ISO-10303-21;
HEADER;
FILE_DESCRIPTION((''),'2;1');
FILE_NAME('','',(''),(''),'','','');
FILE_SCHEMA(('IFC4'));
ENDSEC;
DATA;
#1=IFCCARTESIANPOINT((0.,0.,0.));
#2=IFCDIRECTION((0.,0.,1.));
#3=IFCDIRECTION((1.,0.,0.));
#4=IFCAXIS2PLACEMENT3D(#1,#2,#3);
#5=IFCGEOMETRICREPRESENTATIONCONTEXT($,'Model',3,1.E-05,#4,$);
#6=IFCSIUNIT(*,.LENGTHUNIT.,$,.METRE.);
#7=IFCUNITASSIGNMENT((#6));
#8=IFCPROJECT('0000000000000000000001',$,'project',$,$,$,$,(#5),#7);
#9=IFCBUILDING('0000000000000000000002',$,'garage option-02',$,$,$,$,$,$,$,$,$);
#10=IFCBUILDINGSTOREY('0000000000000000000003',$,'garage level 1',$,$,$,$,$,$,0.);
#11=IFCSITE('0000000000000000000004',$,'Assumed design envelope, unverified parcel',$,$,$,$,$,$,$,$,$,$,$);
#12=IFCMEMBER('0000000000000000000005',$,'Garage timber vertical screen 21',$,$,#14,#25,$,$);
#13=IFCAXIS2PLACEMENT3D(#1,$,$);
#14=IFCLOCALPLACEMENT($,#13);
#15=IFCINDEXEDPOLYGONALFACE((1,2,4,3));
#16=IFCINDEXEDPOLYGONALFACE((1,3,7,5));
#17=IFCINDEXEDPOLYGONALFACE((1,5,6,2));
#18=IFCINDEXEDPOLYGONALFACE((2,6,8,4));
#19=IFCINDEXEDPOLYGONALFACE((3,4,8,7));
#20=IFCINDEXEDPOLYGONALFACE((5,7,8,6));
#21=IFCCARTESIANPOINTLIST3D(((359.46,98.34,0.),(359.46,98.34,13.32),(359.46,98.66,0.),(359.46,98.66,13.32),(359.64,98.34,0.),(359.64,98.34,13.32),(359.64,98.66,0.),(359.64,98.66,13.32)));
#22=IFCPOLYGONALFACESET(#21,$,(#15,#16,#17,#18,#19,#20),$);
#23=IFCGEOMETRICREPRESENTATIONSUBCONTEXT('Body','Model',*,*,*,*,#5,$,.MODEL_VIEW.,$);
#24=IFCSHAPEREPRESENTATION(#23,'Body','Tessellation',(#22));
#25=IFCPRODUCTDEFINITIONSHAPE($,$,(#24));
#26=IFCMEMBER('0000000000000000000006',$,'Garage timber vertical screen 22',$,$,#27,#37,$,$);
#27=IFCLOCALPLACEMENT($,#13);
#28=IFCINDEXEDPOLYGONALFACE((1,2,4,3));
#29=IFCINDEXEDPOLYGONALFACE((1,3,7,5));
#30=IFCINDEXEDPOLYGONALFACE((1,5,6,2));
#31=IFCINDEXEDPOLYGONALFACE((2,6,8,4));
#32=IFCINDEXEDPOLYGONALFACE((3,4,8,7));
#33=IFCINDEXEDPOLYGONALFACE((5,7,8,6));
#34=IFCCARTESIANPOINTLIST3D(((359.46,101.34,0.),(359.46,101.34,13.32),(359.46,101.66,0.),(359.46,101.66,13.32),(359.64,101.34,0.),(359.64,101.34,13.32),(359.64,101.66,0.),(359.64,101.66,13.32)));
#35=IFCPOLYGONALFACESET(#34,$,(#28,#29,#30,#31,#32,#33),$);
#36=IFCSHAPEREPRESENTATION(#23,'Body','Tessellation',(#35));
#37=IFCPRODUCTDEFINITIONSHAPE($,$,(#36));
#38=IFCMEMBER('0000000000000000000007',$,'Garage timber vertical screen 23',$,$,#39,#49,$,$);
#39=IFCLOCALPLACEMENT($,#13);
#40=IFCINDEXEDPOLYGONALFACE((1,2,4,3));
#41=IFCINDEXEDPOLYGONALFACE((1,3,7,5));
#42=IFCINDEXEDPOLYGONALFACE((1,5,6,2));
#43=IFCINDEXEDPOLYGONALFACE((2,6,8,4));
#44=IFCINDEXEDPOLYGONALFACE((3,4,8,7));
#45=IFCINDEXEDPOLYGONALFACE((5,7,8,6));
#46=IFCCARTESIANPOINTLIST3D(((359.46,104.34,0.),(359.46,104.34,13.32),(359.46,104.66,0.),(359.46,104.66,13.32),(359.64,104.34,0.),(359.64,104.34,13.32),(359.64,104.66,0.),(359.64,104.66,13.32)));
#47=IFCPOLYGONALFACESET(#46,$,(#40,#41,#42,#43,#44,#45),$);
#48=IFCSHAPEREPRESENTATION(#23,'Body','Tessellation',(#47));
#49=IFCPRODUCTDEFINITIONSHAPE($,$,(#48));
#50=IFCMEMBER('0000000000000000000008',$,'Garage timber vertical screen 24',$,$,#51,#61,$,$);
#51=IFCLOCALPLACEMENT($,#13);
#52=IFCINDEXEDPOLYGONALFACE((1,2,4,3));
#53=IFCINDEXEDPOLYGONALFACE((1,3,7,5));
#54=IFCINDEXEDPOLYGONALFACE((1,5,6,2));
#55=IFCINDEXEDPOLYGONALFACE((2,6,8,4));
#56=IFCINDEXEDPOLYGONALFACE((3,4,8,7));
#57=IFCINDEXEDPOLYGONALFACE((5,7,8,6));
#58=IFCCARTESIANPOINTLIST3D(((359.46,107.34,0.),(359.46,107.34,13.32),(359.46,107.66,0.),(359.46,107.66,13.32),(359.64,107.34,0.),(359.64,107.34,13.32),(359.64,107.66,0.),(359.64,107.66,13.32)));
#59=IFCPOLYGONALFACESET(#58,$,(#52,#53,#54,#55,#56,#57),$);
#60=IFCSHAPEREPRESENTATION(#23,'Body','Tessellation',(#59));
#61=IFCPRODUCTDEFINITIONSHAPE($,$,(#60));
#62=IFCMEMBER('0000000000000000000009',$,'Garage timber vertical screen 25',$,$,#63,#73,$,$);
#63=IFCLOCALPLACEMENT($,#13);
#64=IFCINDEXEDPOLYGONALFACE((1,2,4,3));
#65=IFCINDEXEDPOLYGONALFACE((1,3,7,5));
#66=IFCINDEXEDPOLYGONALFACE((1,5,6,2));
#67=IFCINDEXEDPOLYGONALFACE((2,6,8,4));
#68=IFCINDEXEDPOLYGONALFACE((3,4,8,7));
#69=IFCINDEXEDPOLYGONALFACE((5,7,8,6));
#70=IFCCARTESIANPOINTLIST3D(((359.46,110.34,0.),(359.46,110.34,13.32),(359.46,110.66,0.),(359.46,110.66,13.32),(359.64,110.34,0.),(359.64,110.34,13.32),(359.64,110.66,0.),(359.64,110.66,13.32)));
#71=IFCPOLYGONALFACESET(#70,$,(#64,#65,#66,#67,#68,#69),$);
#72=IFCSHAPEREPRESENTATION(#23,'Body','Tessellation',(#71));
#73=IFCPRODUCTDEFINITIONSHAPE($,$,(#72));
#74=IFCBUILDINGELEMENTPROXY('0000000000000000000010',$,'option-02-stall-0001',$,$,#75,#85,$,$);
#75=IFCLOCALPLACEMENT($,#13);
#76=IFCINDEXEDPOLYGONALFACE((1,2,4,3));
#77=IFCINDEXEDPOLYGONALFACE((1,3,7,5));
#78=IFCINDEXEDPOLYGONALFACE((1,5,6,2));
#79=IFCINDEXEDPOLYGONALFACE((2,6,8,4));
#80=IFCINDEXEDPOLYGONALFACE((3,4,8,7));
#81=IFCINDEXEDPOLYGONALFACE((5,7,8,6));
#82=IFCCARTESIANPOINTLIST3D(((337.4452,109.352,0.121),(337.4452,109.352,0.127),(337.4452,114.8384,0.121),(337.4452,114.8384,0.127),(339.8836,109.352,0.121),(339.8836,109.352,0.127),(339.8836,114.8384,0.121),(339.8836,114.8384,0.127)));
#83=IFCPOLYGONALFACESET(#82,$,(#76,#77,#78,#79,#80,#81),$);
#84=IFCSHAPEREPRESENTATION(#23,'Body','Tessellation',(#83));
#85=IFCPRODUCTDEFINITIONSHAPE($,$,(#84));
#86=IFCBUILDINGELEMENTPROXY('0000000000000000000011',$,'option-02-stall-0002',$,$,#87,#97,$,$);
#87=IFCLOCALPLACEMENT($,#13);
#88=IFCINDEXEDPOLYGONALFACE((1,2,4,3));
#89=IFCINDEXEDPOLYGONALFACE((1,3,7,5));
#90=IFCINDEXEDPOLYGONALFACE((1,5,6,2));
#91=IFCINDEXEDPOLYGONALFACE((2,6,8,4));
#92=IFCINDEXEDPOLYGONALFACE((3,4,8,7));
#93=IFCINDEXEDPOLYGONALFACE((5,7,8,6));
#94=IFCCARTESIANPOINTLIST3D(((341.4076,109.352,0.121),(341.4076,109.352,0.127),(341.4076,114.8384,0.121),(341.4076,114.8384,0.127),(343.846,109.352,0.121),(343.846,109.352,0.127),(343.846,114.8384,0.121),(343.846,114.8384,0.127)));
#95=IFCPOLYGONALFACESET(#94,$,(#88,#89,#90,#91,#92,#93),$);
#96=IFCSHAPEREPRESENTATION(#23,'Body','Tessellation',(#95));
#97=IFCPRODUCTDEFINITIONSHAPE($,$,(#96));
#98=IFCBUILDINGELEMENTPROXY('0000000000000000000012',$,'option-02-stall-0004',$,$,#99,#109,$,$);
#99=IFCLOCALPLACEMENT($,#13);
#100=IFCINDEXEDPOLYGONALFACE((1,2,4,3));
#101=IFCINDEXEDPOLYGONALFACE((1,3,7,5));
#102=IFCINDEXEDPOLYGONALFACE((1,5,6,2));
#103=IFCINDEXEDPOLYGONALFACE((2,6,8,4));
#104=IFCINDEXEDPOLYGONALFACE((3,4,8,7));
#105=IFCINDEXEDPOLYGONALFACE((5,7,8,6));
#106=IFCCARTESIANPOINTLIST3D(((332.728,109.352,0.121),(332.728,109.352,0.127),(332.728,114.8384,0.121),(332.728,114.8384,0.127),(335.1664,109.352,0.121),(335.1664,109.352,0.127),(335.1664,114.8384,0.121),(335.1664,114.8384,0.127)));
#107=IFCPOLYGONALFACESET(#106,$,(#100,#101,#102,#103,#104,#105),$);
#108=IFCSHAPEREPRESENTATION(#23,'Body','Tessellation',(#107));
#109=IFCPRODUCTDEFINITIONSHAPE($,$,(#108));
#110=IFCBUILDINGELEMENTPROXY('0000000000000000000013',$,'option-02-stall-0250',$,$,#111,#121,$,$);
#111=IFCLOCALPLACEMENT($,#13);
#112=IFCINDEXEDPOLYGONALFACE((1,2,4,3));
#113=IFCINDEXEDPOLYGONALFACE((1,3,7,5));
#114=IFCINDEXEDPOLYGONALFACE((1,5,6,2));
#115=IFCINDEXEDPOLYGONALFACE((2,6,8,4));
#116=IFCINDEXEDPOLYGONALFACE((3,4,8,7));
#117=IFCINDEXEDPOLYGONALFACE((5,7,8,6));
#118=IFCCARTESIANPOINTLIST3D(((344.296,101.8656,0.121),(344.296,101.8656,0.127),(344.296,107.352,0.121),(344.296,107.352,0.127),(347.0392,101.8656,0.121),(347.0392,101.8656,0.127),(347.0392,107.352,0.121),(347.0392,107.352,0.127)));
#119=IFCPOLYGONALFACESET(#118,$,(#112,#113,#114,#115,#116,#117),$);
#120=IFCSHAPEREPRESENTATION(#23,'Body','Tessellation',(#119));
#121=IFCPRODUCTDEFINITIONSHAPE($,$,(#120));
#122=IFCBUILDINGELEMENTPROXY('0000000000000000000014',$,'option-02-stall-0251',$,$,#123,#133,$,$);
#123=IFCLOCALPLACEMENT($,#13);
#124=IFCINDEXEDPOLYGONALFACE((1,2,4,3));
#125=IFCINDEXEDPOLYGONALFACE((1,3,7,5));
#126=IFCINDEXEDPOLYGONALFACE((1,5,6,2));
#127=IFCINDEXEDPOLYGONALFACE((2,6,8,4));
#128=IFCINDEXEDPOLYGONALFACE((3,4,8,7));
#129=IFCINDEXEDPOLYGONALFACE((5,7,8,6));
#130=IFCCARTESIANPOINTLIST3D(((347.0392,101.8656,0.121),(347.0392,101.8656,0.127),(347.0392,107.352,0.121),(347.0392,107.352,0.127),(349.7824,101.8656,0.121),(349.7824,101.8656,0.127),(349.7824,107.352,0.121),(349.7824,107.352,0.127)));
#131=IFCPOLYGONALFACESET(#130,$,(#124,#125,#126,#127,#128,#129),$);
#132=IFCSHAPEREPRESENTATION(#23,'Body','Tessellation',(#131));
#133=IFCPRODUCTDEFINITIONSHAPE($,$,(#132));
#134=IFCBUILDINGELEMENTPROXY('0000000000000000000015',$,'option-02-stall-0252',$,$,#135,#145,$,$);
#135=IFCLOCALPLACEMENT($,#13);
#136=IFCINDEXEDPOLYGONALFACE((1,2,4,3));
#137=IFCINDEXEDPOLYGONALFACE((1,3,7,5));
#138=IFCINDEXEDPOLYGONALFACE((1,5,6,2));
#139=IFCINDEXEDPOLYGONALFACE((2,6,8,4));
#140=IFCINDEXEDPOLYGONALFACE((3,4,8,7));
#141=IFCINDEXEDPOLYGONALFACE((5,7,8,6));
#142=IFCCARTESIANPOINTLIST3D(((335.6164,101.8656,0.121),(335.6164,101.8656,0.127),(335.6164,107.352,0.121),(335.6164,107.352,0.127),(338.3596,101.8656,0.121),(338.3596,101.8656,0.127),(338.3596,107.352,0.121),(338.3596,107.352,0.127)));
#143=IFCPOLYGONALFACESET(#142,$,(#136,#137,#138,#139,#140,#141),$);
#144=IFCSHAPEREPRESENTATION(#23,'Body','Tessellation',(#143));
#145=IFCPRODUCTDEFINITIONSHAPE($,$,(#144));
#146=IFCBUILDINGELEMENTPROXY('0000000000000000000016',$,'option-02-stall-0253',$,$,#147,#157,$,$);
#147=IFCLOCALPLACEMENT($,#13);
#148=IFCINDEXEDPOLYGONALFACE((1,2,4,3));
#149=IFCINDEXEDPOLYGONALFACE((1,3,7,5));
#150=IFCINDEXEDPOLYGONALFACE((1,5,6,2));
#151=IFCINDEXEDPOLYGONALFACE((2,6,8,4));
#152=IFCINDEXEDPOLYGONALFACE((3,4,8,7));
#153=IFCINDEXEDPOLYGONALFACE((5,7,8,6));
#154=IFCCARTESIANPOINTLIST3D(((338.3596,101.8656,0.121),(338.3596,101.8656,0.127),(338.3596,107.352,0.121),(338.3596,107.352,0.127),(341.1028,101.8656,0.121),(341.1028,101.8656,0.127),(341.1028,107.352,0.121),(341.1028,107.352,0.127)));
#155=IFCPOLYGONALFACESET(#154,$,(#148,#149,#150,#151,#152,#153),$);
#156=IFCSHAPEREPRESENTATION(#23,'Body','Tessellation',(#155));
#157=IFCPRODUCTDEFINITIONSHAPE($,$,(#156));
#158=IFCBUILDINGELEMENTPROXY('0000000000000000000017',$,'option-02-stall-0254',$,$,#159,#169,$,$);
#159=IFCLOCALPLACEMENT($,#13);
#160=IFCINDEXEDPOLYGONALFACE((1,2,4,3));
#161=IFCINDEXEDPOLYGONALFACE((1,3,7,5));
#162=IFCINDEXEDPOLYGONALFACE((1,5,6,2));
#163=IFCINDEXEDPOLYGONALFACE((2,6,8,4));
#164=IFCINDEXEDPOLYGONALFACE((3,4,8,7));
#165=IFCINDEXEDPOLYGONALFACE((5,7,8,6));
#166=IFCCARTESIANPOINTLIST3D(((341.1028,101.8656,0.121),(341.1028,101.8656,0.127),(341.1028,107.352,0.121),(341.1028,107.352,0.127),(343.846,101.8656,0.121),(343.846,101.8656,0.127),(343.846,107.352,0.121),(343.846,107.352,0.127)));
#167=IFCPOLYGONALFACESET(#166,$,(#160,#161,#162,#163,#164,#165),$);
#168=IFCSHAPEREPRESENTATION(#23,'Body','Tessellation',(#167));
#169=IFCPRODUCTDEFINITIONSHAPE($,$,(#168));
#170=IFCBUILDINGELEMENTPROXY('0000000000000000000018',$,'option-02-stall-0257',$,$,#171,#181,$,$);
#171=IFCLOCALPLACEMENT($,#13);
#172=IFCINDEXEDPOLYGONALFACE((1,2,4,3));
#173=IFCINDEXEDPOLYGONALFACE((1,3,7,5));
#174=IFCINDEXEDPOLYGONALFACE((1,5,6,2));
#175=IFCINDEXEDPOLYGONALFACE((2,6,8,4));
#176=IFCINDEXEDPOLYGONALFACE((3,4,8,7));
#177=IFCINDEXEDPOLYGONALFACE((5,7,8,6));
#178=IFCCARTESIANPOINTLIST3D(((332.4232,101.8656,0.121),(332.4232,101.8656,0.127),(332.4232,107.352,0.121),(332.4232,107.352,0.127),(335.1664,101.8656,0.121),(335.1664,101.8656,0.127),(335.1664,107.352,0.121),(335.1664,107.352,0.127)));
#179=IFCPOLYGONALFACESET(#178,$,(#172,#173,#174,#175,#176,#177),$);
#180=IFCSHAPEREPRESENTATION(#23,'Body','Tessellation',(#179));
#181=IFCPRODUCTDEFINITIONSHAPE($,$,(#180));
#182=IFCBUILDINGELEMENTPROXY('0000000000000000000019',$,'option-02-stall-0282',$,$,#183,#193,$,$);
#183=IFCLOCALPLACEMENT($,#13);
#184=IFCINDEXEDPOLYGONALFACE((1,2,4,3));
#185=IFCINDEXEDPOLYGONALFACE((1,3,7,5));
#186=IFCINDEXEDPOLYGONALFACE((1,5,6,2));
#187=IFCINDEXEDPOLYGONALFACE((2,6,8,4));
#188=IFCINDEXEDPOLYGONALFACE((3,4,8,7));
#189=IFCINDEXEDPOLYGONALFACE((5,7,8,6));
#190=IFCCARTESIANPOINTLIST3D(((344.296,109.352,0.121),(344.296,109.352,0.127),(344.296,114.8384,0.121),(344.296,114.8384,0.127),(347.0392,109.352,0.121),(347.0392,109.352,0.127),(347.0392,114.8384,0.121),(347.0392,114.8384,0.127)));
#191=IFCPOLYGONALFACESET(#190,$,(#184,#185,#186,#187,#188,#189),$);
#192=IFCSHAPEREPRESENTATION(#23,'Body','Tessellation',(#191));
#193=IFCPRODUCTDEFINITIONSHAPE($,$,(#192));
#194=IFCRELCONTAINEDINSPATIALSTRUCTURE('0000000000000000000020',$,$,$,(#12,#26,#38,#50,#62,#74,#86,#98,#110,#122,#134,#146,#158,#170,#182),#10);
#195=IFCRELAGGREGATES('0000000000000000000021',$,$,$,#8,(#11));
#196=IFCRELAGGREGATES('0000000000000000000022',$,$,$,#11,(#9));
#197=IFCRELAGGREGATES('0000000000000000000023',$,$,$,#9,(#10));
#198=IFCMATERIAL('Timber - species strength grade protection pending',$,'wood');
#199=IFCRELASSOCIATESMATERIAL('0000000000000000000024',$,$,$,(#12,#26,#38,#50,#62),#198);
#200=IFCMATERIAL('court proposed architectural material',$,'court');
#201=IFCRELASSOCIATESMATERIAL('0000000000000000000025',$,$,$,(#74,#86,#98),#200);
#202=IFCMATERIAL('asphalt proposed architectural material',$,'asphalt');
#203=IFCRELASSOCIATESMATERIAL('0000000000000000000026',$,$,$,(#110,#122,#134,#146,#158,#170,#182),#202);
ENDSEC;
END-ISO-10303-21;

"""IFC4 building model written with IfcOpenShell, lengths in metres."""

from ifc_helpers import new_model, si_unit, frame, origin_with_axes, place, context, subcontext, project, spatial, rectangle, extrude, material, element, save


model = new_model("IFC4")

# Units and contexts
model_context = context("Model", 3, precision=1e-05, world=origin_with_axes())
body_context = subcontext(model_context, "Body", "Model", "MODEL_VIEW")
ifc_project = project(units=[si_unit("LENGTHUNIT", "METRE")], contexts=[model_context])

# Site, building, storey
site = spatial("IfcSite", under=ifc_project, Name="Assumed design envelope, unverified parcel")
building = spatial("IfcBuilding", under=site, Name="garage option-02")
storey = spatial("IfcBuildingStorey", under=building, Name="garage level 1", Elevation=0.0)

# Members
ifc_material_1 = material(Name="Timber - species strength grade protection pending", Category="wood")
for number, where, z_axis, x_axis, name in (
    (1, (359.55, 98.5, 0.0), (0.0, 0.0, 1.0), (1.0, 0.0, 0.0), "Garage timber vertical screen 21"),
    (2, (359.55, 101.5, 0.0), (0.0, 0.0, 1.0), (1.0, 0.0, 0.0), "Garage timber vertical screen 22"),
    (3, (359.55, 104.5, 0.0), (0.0, 0.0, 1.0), (1.0, 0.0, 0.0), "Garage timber vertical screen 23"),
    (4, (359.55, 107.5, 0.0), (0.0, 0.0, 1.0), (1.0, 0.0, 0.0), "Garage timber vertical screen 24"),
    (5, (359.55, 110.5, 0.0), (0.0, 0.0, 1.0), (1.0, 0.0, 0.0), "Garage timber vertical screen 25"),
):
    element("IfcMember", number, at=place(None, frame(where, z_axis=z_axis, x_axis=x_axis)), inside=storey, material=ifc_material_1, Name=name, context=body_context, shape_type="SweptSolid", body=[
        extrude(rectangle(XDim=0.18, YDim=0.32), origin_with_axes(), (0.0, 0.0, 1.0), 13.32),
    ])

# Building element proxies
ifc_material_2 = material(Name="court proposed architectural material", Category="court")
for number, where, z_axis, x_axis, name in (
    (6, (338.6644, 112.0952, 0.121), (0.0, 0.0, 1.0), (1.0, 0.0, 0.0), "option-02-stall-0001"),
    (7, (342.6268, 112.0952, 0.121), (0.0, 0.0, 1.0), (1.0, 0.0, 0.0), "option-02-stall-0002"),
    (8, (333.9472, 112.0952, 0.121), (0.0, 0.0, 1.0), (1.0, 0.0, 0.0), "option-02-stall-0004"),
):
    element("IfcBuildingElementProxy", number, at=place(None, frame(where, z_axis=z_axis, x_axis=x_axis)), inside=storey, material=ifc_material_2, Name=name, context=body_context, shape_type="SweptSolid", body=[
        extrude(rectangle(XDim=2.4384, YDim=5.4864), origin_with_axes(), (0.0, 0.0, 1.0), 0.006),
    ])
ifc_material_3 = material(Name="asphalt proposed architectural material", Category="asphalt")
for number, where, z_axis, x_axis, name in (
    (9, (345.6676, 104.6088, 0.121), (0.0, 0.0, 1.0), (1.0, 0.0, 0.0), "option-02-stall-0250"),
    (10, (348.4108, 104.6088, 0.121), (0.0, 0.0, 1.0), (1.0, 0.0, 0.0), "option-02-stall-0251"),
    (11, (336.988, 104.6088, 0.121), (0.0, 0.0, 1.0), (1.0, 0.0, 0.0), "option-02-stall-0252"),
    (12, (339.7312, 104.6088, 0.121), (0.0, 0.0, 1.0), (1.0, 0.0, 0.0), "option-02-stall-0253"),
    (13, (342.4744, 104.6088, 0.121), (0.0, 0.0, 1.0), (1.0, 0.0, 0.0), "option-02-stall-0254"),
    (14, (333.7948, 104.6088, 0.121), (0.0, 0.0, 1.0), (1.0, 0.0, 0.0), "option-02-stall-0257"),
    (15, (345.6676, 112.0952, 0.121), (0.0, 0.0, 1.0), (1.0, 0.0, 0.0), "option-02-stall-0282"),
):
    element("IfcBuildingElementProxy", number, at=place(None, frame(where, z_axis=z_axis, x_axis=x_axis)), inside=storey, material=ifc_material_3, Name=name, context=body_context, shape_type="SweptSolid", body=[
        extrude(rectangle(XDim=2.7432, YDim=5.4864), origin_with_axes(), (0.0, 0.0, 1.0), 0.006),
    ])

save(model, "model.ifc")
